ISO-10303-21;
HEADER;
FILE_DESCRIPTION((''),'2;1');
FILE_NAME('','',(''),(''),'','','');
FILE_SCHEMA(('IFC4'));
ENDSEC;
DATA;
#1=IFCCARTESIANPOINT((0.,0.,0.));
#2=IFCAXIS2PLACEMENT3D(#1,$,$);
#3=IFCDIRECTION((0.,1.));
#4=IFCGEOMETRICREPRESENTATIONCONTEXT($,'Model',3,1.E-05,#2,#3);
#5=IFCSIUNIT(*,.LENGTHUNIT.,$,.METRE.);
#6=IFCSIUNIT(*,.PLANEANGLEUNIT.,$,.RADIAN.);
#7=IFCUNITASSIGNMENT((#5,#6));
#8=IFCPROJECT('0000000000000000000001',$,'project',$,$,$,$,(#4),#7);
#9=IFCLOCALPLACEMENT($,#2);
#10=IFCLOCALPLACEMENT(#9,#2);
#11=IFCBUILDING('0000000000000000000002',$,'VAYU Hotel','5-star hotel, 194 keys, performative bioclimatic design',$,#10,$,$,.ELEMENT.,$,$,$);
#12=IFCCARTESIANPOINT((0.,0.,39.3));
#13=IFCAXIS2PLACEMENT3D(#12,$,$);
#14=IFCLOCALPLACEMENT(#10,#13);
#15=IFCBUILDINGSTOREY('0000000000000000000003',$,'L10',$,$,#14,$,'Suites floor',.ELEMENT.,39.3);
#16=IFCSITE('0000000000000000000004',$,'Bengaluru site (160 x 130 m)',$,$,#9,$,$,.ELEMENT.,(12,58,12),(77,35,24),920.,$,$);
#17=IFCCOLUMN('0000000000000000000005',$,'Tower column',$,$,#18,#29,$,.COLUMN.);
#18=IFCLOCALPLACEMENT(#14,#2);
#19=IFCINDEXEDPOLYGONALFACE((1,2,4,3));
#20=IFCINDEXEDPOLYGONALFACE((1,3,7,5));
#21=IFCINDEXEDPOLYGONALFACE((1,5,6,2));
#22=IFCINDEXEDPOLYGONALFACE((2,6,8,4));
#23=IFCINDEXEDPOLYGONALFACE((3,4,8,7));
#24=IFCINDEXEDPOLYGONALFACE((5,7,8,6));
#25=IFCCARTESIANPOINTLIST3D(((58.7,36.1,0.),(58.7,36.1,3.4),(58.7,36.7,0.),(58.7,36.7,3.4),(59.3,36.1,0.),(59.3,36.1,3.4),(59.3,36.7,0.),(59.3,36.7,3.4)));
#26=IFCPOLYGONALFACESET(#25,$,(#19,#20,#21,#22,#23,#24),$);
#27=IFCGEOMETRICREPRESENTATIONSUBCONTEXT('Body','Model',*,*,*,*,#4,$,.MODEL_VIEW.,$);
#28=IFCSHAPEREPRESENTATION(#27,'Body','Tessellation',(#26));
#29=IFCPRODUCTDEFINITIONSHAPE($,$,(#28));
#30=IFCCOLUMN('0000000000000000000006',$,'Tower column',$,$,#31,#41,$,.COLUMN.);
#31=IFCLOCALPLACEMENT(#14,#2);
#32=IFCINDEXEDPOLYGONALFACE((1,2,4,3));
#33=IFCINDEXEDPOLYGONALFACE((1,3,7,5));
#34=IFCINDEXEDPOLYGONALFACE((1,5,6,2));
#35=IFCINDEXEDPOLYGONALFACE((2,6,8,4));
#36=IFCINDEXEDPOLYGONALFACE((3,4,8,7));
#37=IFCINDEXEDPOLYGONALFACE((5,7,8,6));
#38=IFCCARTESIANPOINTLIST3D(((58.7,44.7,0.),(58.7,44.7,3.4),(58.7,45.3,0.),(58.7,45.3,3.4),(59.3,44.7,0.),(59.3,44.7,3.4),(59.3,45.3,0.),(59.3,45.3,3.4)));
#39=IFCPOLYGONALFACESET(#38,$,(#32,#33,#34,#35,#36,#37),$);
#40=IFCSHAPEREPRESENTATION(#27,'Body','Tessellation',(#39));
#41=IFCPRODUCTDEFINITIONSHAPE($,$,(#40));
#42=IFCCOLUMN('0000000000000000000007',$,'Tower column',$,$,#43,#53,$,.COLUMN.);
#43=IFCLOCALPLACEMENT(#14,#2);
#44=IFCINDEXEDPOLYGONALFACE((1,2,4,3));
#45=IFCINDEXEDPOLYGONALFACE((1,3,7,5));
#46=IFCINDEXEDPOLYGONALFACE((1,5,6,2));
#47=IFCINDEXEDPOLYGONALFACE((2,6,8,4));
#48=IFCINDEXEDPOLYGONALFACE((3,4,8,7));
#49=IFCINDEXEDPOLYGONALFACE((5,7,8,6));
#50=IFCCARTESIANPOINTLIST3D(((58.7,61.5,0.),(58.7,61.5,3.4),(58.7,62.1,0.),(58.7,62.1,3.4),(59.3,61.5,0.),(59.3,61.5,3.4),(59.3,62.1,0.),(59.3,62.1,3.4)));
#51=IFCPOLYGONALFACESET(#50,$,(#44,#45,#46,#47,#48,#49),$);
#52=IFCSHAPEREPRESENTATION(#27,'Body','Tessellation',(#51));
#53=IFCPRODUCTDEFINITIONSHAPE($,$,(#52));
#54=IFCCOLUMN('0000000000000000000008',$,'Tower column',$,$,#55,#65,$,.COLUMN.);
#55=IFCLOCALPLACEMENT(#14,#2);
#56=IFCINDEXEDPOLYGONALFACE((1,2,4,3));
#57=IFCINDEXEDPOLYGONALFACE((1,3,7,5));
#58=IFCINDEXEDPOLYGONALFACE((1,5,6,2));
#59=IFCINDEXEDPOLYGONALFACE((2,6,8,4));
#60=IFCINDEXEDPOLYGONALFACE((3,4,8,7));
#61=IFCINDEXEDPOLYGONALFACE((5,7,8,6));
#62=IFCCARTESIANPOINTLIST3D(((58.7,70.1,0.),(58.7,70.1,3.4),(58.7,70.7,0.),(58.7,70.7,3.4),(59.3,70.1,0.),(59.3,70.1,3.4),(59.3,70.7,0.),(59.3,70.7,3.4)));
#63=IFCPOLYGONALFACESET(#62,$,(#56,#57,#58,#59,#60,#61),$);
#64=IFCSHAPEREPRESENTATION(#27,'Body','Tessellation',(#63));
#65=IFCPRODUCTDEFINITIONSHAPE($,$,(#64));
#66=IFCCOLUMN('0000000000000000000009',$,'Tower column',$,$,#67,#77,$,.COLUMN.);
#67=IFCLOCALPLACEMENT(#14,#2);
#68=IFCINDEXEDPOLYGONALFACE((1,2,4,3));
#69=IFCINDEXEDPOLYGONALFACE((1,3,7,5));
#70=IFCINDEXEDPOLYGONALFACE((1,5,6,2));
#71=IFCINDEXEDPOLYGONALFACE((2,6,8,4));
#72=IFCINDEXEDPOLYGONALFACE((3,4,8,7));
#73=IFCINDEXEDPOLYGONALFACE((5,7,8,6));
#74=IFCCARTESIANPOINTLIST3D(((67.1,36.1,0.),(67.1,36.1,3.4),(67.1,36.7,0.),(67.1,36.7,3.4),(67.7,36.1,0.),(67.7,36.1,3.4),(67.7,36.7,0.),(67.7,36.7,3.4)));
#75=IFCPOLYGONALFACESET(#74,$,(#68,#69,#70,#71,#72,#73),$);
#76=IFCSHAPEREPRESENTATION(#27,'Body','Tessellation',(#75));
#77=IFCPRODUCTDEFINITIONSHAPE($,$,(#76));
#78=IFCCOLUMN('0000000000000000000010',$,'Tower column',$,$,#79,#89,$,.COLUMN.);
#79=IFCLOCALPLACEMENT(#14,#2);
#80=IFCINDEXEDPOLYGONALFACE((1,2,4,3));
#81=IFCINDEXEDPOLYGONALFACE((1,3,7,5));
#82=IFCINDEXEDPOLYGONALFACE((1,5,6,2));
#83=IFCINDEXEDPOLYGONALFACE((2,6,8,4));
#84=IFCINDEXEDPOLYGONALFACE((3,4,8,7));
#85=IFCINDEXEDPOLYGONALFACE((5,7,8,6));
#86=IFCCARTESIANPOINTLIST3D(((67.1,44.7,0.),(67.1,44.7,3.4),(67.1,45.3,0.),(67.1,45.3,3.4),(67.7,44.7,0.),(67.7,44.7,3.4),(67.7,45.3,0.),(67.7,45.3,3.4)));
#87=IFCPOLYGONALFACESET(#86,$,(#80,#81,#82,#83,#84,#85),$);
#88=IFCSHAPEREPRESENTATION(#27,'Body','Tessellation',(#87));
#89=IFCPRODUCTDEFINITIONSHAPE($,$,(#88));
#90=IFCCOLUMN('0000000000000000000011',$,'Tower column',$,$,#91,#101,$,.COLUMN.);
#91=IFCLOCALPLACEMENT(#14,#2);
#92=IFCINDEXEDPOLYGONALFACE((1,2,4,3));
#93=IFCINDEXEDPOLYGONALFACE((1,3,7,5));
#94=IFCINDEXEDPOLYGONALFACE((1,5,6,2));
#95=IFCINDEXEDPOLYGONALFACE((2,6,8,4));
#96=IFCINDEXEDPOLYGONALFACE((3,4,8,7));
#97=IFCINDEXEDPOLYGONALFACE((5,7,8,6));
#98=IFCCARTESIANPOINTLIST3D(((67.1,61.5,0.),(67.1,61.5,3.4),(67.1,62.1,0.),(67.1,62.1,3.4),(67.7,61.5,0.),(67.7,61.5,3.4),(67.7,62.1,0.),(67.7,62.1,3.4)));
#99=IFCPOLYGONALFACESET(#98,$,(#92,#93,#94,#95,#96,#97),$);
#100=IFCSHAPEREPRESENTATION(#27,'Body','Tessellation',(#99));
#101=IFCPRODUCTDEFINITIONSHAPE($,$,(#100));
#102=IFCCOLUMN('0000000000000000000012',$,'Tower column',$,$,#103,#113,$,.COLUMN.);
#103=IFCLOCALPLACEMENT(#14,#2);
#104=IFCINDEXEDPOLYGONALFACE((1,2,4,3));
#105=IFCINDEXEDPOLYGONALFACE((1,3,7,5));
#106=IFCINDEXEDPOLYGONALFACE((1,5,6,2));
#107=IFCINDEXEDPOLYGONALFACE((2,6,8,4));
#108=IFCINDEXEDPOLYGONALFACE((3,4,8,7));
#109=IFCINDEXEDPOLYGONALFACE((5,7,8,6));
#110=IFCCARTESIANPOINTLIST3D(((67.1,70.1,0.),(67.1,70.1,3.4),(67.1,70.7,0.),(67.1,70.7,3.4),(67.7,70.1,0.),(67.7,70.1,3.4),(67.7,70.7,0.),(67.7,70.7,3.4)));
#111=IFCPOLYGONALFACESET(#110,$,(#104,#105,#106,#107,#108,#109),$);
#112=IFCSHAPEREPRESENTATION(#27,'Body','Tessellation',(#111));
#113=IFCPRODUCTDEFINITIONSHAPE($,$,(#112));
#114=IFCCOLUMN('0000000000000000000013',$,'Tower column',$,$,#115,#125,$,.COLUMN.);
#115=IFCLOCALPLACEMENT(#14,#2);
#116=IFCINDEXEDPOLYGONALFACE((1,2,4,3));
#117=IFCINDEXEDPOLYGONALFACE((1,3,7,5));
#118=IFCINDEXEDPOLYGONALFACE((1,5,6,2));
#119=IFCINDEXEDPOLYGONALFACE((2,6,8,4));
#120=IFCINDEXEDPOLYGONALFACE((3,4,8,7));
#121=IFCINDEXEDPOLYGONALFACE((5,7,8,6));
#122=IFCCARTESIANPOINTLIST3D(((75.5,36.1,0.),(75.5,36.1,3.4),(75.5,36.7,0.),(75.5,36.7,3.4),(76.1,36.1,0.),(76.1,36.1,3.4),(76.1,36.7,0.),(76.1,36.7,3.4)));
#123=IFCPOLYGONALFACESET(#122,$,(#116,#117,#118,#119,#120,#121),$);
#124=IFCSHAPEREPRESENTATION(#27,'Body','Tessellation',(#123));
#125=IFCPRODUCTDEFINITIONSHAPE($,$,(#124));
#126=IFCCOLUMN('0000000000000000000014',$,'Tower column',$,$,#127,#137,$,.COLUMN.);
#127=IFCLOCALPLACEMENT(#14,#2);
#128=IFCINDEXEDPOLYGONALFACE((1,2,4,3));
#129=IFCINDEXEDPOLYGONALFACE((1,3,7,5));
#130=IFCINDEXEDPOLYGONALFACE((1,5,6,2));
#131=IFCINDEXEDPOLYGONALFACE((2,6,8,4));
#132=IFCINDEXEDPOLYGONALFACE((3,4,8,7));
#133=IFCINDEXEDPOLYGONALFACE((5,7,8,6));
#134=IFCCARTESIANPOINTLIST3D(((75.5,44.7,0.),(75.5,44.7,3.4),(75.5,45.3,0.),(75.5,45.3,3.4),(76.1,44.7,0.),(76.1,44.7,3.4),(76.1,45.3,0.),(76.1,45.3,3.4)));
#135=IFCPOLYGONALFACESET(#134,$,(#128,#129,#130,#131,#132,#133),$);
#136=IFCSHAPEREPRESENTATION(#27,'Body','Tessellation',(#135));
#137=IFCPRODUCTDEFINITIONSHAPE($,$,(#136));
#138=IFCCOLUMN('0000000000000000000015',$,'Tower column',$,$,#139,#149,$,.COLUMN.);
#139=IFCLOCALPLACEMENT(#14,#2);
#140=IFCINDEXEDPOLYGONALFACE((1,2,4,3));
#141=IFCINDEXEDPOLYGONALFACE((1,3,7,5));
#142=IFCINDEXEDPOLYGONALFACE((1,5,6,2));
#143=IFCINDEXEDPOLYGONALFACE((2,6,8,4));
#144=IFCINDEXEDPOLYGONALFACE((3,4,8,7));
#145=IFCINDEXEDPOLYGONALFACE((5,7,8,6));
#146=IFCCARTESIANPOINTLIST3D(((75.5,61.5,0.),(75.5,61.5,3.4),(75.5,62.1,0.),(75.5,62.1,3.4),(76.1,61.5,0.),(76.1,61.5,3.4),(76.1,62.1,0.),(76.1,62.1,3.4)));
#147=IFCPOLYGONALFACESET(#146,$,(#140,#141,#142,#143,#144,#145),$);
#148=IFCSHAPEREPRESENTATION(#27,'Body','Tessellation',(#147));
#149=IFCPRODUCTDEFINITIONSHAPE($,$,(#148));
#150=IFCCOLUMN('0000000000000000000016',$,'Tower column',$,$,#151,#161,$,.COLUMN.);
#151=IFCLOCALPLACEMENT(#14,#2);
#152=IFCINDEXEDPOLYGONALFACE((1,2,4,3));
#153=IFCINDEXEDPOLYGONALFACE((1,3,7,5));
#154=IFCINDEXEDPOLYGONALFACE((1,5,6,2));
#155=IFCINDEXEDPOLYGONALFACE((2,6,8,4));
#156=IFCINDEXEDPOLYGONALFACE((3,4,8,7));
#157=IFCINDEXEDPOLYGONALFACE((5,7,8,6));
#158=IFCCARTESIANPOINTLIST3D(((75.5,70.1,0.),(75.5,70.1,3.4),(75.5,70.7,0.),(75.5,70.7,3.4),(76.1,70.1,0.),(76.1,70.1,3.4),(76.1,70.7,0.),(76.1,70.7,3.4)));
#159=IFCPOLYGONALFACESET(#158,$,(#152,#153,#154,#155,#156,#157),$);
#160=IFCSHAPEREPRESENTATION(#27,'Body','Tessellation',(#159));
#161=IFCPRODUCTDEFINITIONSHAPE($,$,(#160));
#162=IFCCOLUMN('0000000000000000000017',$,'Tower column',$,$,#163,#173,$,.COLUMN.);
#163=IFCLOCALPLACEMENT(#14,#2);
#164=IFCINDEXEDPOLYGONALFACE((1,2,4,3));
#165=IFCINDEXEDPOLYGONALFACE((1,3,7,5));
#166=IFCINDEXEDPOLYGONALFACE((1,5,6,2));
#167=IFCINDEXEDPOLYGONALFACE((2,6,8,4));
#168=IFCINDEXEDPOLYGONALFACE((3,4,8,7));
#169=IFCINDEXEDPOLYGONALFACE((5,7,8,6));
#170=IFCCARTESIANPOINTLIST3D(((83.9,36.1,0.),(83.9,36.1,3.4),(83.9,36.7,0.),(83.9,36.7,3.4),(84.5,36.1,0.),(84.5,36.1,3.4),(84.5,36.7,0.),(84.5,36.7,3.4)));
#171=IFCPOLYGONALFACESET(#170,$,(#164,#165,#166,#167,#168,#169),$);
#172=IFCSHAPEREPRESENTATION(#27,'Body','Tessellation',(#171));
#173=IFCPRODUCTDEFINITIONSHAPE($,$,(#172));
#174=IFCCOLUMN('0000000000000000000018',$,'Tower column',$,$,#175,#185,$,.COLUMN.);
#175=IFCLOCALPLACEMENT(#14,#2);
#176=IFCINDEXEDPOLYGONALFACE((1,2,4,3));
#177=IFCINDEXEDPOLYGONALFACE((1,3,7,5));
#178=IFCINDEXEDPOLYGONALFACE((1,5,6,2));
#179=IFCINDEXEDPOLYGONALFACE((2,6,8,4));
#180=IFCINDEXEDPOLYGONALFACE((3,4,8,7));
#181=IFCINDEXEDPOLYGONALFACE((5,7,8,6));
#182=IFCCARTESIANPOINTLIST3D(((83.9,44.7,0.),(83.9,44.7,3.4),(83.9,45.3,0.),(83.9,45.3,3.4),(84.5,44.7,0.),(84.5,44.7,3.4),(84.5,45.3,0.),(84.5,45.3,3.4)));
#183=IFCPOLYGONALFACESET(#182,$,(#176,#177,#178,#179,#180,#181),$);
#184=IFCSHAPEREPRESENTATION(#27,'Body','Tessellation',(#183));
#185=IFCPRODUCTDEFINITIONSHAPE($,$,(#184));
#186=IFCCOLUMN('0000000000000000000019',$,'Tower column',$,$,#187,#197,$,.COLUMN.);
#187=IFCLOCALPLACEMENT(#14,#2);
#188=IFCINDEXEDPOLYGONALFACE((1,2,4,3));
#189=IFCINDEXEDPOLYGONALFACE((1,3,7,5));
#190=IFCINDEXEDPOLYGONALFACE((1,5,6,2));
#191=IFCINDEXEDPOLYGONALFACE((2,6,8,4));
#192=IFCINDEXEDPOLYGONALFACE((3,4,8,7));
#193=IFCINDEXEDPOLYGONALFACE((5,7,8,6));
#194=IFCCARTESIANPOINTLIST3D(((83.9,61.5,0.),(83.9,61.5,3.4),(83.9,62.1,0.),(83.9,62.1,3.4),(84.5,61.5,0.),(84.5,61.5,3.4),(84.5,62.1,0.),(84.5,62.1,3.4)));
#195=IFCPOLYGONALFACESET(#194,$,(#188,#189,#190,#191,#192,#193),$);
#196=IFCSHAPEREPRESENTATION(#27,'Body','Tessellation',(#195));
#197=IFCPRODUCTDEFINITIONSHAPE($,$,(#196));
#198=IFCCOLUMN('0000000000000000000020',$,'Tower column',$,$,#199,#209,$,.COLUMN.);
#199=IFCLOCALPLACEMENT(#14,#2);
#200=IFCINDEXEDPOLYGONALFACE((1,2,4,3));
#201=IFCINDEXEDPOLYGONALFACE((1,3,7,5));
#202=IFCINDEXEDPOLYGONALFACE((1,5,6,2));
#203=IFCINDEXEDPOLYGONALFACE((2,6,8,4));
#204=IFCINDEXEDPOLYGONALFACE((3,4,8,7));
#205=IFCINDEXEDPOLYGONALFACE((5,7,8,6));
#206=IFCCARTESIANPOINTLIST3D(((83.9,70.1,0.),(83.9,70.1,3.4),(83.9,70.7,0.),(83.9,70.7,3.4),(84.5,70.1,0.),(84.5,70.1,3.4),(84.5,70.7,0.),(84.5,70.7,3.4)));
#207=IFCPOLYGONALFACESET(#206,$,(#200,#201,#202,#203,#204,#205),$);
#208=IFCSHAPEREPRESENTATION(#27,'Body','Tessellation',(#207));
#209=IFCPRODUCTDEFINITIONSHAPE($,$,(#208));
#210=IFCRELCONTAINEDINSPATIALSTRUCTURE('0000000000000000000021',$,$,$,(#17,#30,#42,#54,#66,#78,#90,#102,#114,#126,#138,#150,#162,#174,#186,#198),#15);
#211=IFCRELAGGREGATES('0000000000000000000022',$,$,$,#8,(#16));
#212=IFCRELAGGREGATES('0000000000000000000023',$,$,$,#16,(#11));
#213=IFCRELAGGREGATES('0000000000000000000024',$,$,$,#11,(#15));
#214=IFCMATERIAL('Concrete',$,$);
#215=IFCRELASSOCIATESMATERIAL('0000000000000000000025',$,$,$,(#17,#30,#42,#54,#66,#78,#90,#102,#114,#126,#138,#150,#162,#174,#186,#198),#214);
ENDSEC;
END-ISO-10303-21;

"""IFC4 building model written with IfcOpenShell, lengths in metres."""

from ifc_helpers import new_model, si_unit, direction, frame, origin, place, context, subcontext, project, spatial, polyline, outline, extrude, material, element, save


model = new_model("IFC4")

# Units and contexts
model_context = context("Model", 3, precision=1e-05, world=origin(), true_north=direction((0.0, 1.0)))
body_context = subcontext(model_context, "Body", "Model", "MODEL_VIEW")
ifc_project = project(units=[si_unit("LENGTHUNIT", "METRE"), si_unit("PLANEANGLEUNIT", "RADIAN")], contexts=[model_context])

# Site, building, storey
site_placement = place(None, origin())
site = spatial("IfcSite", under=ifc_project, at=site_placement, Name="Bengaluru site (160 x 130 m)", CompositionType="ELEMENT", RefLatitude=(12, 58, 12), RefLongitude=(77, 35, 24), RefElevation=920.0)
building_placement = place(site_placement, origin())
building = spatial("IfcBuilding", under=site, at=building_placement, Name="VAYU Hotel", Description="5-star hotel, 194 keys, performative bioclimatic design", CompositionType="ELEMENT")
storey_placement = place(building_placement, frame((0.0, 0.0, 39.3)))
storey = spatial("IfcBuildingStorey", under=building, at=storey_placement, Name="L10", LongName="Suites floor", CompositionType="ELEMENT", Elevation=39.3)

# Columns
ifc_material_1 = material(Name="Concrete")
column_1_placement = place(storey_placement, origin())
element("IfcColumn", 1, at=column_1_placement, inside=storey, material=ifc_material_1, Name="Tower column", PredefinedType="COLUMN", context=body_context, shape_type="SweptSolid", body=[
    extrude(outline(polyline([(58.7, 36.1), (59.3, 36.1), (59.3, 36.7), (58.7, 36.7), (58.7, 36.1)])), origin(), (0.0, 0.0, 1.0), 3.4),
])
column_2_placement = place(storey_placement, origin())
element("IfcColumn", 2, at=column_2_placement, inside=storey, material=ifc_material_1, Name="Tower column", PredefinedType="COLUMN", context=body_context, shape_type="SweptSolid", body=[
    extrude(outline(polyline([(58.7, 44.7), (59.3, 44.7), (59.3, 45.3), (58.7, 45.3), (58.7, 44.7)])), origin(), (0.0, 0.0, 1.0), 3.4),
])
column_3_placement = place(storey_placement, origin())
element("IfcColumn", 3, at=column_3_placement, inside=storey, material=ifc_material_1, Name="Tower column", PredefinedType="COLUMN", context=body_context, shape_type="SweptSolid", body=[
    extrude(outline(polyline([(58.7, 61.5), (59.3, 61.5), (59.3, 62.1), (58.7, 62.1), (58.7, 61.5)])), origin(), (0.0, 0.0, 1.0), 3.4),
])
column_4_placement = place(storey_placement, origin())
element("IfcColumn", 4, at=column_4_placement, inside=storey, material=ifc_material_1, Name="Tower column", PredefinedType="COLUMN", context=body_context, shape_type="SweptSolid", body=[
    extrude(outline(polyline([(58.7, 70.1), (59.3, 70.1), (59.3, 70.7), (58.7, 70.7), (58.7, 70.1)])), origin(), (0.0, 0.0, 1.0), 3.4),
])
column_5_placement = place(storey_placement, origin())
element("IfcColumn", 5, at=column_5_placement, inside=storey, material=ifc_material_1, Name="Tower column", PredefinedType="COLUMN", context=body_context, shape_type="SweptSolid", body=[
    extrude(outline(polyline([(67.1, 36.1), (67.7, 36.1), (67.7, 36.7), (67.1, 36.7), (67.1, 36.1)])), origin(), (0.0, 0.0, 1.0), 3.4),
])
column_6_placement = place(storey_placement, origin())
element("IfcColumn", 6, at=column_6_placement, inside=storey, material=ifc_material_1, Name="Tower column", PredefinedType="COLUMN", context=body_context, shape_type="SweptSolid", body=[
    extrude(outline(polyline([(67.1, 44.7), (67.7, 44.7), (67.7, 45.3), (67.1, 45.3), (67.1, 44.7)])), origin(), (0.0, 0.0, 1.0), 3.4),
])
column_7_placement = place(storey_placement, origin())
element("IfcColumn", 7, at=column_7_placement, inside=storey, material=ifc_material_1, Name="Tower column", PredefinedType="COLUMN", context=body_context, shape_type="SweptSolid", body=[
    extrude(outline(polyline([(67.1, 61.5), (67.7, 61.5), (67.7, 62.1), (67.1, 62.1), (67.1, 61.5)])), origin(), (0.0, 0.0, 1.0), 3.4),
])
column_8_placement = place(storey_placement, origin())
element("IfcColumn", 8, at=column_8_placement, inside=storey, material=ifc_material_1, Name="Tower column", PredefinedType="COLUMN", context=body_context, shape_type="SweptSolid", body=[
    extrude(outline(polyline([(67.1, 70.1), (67.7, 70.1), (67.7, 70.7), (67.1, 70.7), (67.1, 70.1)])), origin(), (0.0, 0.0, 1.0), 3.4),
])
column_9_placement = place(storey_placement, origin())
element("IfcColumn", 9, at=column_9_placement, inside=storey, material=ifc_material_1, Name="Tower column", PredefinedType="COLUMN", context=body_context, shape_type="SweptSolid", body=[
    extrude(outline(polyline([(75.5, 36.1), (76.1, 36.1), (76.1, 36.7), (75.5, 36.7), (75.5, 36.1)])), origin(), (0.0, 0.0, 1.0), 3.4),
])
column_10_placement = place(storey_placement, origin())
element("IfcColumn", 10, at=column_10_placement, inside=storey, material=ifc_material_1, Name="Tower column", PredefinedType="COLUMN", context=body_context, shape_type="SweptSolid", body=[
    extrude(outline(polyline([(75.5, 44.7), (76.1, 44.7), (76.1, 45.3), (75.5, 45.3), (75.5, 44.7)])), origin(), (0.0, 0.0, 1.0), 3.4),
])
column_11_placement = place(storey_placement, origin())
element("IfcColumn", 11, at=column_11_placement, inside=storey, material=ifc_material_1, Name="Tower column", PredefinedType="COLUMN", context=body_context, shape_type="SweptSolid", body=[
    extrude(outline(polyline([(75.5, 61.5), (76.1, 61.5), (76.1, 62.1), (75.5, 62.1), (75.5, 61.5)])), origin(), (0.0, 0.0, 1.0), 3.4),
])
column_12_placement = place(storey_placement, origin())
element("IfcColumn", 12, at=column_12_placement, inside=storey, material=ifc_material_1, Name="Tower column", PredefinedType="COLUMN", context=body_context, shape_type="SweptSolid", body=[
    extrude(outline(polyline([(75.5, 70.1), (76.1, 70.1), (76.1, 70.7), (75.5, 70.7), (75.5, 70.1)])), origin(), (0.0, 0.0, 1.0), 3.4),
])
column_13_placement = place(storey_placement, origin())
element("IfcColumn", 13, at=column_13_placement, inside=storey, material=ifc_material_1, Name="Tower column", PredefinedType="COLUMN", context=body_context, shape_type="SweptSolid", body=[
    extrude(outline(polyline([(83.9, 36.1), (84.5, 36.1), (84.5, 36.7), (83.9, 36.7), (83.9, 36.1)])), origin(), (0.0, 0.0, 1.0), 3.4),
])
column_14_placement = place(storey_placement, origin())
element("IfcColumn", 14, at=column_14_placement, inside=storey, material=ifc_material_1, Name="Tower column", PredefinedType="COLUMN", context=body_context, shape_type="SweptSolid", body=[
    extrude(outline(polyline([(83.9, 44.7), (84.5, 44.7), (84.5, 45.3), (83.9, 45.3), (83.9, 44.7)])), origin(), (0.0, 0.0, 1.0), 3.4),
])
column_15_placement = place(storey_placement, origin())
element("IfcColumn", 15, at=column_15_placement, inside=storey, material=ifc_material_1, Name="Tower column", PredefinedType="COLUMN", context=body_context, shape_type="SweptSolid", body=[
    extrude(outline(polyline([(83.9, 61.5), (84.5, 61.5), (84.5, 62.1), (83.9, 62.1), (83.9, 61.5)])), origin(), (0.0, 0.0, 1.0), 3.4),
])
column_16_placement = place(storey_placement, origin())
element("IfcColumn", 16, at=column_16_placement, inside=storey, material=ifc_material_1, Name="Tower column", PredefinedType="COLUMN", context=body_context, shape_type="SweptSolid", body=[
    extrude(outline(polyline([(83.9, 70.1), (84.5, 70.1), (84.5, 70.7), (83.9, 70.7), (83.9, 70.1)])), origin(), (0.0, 0.0, 1.0), 3.4),
])

save(model, "model.ifc")
